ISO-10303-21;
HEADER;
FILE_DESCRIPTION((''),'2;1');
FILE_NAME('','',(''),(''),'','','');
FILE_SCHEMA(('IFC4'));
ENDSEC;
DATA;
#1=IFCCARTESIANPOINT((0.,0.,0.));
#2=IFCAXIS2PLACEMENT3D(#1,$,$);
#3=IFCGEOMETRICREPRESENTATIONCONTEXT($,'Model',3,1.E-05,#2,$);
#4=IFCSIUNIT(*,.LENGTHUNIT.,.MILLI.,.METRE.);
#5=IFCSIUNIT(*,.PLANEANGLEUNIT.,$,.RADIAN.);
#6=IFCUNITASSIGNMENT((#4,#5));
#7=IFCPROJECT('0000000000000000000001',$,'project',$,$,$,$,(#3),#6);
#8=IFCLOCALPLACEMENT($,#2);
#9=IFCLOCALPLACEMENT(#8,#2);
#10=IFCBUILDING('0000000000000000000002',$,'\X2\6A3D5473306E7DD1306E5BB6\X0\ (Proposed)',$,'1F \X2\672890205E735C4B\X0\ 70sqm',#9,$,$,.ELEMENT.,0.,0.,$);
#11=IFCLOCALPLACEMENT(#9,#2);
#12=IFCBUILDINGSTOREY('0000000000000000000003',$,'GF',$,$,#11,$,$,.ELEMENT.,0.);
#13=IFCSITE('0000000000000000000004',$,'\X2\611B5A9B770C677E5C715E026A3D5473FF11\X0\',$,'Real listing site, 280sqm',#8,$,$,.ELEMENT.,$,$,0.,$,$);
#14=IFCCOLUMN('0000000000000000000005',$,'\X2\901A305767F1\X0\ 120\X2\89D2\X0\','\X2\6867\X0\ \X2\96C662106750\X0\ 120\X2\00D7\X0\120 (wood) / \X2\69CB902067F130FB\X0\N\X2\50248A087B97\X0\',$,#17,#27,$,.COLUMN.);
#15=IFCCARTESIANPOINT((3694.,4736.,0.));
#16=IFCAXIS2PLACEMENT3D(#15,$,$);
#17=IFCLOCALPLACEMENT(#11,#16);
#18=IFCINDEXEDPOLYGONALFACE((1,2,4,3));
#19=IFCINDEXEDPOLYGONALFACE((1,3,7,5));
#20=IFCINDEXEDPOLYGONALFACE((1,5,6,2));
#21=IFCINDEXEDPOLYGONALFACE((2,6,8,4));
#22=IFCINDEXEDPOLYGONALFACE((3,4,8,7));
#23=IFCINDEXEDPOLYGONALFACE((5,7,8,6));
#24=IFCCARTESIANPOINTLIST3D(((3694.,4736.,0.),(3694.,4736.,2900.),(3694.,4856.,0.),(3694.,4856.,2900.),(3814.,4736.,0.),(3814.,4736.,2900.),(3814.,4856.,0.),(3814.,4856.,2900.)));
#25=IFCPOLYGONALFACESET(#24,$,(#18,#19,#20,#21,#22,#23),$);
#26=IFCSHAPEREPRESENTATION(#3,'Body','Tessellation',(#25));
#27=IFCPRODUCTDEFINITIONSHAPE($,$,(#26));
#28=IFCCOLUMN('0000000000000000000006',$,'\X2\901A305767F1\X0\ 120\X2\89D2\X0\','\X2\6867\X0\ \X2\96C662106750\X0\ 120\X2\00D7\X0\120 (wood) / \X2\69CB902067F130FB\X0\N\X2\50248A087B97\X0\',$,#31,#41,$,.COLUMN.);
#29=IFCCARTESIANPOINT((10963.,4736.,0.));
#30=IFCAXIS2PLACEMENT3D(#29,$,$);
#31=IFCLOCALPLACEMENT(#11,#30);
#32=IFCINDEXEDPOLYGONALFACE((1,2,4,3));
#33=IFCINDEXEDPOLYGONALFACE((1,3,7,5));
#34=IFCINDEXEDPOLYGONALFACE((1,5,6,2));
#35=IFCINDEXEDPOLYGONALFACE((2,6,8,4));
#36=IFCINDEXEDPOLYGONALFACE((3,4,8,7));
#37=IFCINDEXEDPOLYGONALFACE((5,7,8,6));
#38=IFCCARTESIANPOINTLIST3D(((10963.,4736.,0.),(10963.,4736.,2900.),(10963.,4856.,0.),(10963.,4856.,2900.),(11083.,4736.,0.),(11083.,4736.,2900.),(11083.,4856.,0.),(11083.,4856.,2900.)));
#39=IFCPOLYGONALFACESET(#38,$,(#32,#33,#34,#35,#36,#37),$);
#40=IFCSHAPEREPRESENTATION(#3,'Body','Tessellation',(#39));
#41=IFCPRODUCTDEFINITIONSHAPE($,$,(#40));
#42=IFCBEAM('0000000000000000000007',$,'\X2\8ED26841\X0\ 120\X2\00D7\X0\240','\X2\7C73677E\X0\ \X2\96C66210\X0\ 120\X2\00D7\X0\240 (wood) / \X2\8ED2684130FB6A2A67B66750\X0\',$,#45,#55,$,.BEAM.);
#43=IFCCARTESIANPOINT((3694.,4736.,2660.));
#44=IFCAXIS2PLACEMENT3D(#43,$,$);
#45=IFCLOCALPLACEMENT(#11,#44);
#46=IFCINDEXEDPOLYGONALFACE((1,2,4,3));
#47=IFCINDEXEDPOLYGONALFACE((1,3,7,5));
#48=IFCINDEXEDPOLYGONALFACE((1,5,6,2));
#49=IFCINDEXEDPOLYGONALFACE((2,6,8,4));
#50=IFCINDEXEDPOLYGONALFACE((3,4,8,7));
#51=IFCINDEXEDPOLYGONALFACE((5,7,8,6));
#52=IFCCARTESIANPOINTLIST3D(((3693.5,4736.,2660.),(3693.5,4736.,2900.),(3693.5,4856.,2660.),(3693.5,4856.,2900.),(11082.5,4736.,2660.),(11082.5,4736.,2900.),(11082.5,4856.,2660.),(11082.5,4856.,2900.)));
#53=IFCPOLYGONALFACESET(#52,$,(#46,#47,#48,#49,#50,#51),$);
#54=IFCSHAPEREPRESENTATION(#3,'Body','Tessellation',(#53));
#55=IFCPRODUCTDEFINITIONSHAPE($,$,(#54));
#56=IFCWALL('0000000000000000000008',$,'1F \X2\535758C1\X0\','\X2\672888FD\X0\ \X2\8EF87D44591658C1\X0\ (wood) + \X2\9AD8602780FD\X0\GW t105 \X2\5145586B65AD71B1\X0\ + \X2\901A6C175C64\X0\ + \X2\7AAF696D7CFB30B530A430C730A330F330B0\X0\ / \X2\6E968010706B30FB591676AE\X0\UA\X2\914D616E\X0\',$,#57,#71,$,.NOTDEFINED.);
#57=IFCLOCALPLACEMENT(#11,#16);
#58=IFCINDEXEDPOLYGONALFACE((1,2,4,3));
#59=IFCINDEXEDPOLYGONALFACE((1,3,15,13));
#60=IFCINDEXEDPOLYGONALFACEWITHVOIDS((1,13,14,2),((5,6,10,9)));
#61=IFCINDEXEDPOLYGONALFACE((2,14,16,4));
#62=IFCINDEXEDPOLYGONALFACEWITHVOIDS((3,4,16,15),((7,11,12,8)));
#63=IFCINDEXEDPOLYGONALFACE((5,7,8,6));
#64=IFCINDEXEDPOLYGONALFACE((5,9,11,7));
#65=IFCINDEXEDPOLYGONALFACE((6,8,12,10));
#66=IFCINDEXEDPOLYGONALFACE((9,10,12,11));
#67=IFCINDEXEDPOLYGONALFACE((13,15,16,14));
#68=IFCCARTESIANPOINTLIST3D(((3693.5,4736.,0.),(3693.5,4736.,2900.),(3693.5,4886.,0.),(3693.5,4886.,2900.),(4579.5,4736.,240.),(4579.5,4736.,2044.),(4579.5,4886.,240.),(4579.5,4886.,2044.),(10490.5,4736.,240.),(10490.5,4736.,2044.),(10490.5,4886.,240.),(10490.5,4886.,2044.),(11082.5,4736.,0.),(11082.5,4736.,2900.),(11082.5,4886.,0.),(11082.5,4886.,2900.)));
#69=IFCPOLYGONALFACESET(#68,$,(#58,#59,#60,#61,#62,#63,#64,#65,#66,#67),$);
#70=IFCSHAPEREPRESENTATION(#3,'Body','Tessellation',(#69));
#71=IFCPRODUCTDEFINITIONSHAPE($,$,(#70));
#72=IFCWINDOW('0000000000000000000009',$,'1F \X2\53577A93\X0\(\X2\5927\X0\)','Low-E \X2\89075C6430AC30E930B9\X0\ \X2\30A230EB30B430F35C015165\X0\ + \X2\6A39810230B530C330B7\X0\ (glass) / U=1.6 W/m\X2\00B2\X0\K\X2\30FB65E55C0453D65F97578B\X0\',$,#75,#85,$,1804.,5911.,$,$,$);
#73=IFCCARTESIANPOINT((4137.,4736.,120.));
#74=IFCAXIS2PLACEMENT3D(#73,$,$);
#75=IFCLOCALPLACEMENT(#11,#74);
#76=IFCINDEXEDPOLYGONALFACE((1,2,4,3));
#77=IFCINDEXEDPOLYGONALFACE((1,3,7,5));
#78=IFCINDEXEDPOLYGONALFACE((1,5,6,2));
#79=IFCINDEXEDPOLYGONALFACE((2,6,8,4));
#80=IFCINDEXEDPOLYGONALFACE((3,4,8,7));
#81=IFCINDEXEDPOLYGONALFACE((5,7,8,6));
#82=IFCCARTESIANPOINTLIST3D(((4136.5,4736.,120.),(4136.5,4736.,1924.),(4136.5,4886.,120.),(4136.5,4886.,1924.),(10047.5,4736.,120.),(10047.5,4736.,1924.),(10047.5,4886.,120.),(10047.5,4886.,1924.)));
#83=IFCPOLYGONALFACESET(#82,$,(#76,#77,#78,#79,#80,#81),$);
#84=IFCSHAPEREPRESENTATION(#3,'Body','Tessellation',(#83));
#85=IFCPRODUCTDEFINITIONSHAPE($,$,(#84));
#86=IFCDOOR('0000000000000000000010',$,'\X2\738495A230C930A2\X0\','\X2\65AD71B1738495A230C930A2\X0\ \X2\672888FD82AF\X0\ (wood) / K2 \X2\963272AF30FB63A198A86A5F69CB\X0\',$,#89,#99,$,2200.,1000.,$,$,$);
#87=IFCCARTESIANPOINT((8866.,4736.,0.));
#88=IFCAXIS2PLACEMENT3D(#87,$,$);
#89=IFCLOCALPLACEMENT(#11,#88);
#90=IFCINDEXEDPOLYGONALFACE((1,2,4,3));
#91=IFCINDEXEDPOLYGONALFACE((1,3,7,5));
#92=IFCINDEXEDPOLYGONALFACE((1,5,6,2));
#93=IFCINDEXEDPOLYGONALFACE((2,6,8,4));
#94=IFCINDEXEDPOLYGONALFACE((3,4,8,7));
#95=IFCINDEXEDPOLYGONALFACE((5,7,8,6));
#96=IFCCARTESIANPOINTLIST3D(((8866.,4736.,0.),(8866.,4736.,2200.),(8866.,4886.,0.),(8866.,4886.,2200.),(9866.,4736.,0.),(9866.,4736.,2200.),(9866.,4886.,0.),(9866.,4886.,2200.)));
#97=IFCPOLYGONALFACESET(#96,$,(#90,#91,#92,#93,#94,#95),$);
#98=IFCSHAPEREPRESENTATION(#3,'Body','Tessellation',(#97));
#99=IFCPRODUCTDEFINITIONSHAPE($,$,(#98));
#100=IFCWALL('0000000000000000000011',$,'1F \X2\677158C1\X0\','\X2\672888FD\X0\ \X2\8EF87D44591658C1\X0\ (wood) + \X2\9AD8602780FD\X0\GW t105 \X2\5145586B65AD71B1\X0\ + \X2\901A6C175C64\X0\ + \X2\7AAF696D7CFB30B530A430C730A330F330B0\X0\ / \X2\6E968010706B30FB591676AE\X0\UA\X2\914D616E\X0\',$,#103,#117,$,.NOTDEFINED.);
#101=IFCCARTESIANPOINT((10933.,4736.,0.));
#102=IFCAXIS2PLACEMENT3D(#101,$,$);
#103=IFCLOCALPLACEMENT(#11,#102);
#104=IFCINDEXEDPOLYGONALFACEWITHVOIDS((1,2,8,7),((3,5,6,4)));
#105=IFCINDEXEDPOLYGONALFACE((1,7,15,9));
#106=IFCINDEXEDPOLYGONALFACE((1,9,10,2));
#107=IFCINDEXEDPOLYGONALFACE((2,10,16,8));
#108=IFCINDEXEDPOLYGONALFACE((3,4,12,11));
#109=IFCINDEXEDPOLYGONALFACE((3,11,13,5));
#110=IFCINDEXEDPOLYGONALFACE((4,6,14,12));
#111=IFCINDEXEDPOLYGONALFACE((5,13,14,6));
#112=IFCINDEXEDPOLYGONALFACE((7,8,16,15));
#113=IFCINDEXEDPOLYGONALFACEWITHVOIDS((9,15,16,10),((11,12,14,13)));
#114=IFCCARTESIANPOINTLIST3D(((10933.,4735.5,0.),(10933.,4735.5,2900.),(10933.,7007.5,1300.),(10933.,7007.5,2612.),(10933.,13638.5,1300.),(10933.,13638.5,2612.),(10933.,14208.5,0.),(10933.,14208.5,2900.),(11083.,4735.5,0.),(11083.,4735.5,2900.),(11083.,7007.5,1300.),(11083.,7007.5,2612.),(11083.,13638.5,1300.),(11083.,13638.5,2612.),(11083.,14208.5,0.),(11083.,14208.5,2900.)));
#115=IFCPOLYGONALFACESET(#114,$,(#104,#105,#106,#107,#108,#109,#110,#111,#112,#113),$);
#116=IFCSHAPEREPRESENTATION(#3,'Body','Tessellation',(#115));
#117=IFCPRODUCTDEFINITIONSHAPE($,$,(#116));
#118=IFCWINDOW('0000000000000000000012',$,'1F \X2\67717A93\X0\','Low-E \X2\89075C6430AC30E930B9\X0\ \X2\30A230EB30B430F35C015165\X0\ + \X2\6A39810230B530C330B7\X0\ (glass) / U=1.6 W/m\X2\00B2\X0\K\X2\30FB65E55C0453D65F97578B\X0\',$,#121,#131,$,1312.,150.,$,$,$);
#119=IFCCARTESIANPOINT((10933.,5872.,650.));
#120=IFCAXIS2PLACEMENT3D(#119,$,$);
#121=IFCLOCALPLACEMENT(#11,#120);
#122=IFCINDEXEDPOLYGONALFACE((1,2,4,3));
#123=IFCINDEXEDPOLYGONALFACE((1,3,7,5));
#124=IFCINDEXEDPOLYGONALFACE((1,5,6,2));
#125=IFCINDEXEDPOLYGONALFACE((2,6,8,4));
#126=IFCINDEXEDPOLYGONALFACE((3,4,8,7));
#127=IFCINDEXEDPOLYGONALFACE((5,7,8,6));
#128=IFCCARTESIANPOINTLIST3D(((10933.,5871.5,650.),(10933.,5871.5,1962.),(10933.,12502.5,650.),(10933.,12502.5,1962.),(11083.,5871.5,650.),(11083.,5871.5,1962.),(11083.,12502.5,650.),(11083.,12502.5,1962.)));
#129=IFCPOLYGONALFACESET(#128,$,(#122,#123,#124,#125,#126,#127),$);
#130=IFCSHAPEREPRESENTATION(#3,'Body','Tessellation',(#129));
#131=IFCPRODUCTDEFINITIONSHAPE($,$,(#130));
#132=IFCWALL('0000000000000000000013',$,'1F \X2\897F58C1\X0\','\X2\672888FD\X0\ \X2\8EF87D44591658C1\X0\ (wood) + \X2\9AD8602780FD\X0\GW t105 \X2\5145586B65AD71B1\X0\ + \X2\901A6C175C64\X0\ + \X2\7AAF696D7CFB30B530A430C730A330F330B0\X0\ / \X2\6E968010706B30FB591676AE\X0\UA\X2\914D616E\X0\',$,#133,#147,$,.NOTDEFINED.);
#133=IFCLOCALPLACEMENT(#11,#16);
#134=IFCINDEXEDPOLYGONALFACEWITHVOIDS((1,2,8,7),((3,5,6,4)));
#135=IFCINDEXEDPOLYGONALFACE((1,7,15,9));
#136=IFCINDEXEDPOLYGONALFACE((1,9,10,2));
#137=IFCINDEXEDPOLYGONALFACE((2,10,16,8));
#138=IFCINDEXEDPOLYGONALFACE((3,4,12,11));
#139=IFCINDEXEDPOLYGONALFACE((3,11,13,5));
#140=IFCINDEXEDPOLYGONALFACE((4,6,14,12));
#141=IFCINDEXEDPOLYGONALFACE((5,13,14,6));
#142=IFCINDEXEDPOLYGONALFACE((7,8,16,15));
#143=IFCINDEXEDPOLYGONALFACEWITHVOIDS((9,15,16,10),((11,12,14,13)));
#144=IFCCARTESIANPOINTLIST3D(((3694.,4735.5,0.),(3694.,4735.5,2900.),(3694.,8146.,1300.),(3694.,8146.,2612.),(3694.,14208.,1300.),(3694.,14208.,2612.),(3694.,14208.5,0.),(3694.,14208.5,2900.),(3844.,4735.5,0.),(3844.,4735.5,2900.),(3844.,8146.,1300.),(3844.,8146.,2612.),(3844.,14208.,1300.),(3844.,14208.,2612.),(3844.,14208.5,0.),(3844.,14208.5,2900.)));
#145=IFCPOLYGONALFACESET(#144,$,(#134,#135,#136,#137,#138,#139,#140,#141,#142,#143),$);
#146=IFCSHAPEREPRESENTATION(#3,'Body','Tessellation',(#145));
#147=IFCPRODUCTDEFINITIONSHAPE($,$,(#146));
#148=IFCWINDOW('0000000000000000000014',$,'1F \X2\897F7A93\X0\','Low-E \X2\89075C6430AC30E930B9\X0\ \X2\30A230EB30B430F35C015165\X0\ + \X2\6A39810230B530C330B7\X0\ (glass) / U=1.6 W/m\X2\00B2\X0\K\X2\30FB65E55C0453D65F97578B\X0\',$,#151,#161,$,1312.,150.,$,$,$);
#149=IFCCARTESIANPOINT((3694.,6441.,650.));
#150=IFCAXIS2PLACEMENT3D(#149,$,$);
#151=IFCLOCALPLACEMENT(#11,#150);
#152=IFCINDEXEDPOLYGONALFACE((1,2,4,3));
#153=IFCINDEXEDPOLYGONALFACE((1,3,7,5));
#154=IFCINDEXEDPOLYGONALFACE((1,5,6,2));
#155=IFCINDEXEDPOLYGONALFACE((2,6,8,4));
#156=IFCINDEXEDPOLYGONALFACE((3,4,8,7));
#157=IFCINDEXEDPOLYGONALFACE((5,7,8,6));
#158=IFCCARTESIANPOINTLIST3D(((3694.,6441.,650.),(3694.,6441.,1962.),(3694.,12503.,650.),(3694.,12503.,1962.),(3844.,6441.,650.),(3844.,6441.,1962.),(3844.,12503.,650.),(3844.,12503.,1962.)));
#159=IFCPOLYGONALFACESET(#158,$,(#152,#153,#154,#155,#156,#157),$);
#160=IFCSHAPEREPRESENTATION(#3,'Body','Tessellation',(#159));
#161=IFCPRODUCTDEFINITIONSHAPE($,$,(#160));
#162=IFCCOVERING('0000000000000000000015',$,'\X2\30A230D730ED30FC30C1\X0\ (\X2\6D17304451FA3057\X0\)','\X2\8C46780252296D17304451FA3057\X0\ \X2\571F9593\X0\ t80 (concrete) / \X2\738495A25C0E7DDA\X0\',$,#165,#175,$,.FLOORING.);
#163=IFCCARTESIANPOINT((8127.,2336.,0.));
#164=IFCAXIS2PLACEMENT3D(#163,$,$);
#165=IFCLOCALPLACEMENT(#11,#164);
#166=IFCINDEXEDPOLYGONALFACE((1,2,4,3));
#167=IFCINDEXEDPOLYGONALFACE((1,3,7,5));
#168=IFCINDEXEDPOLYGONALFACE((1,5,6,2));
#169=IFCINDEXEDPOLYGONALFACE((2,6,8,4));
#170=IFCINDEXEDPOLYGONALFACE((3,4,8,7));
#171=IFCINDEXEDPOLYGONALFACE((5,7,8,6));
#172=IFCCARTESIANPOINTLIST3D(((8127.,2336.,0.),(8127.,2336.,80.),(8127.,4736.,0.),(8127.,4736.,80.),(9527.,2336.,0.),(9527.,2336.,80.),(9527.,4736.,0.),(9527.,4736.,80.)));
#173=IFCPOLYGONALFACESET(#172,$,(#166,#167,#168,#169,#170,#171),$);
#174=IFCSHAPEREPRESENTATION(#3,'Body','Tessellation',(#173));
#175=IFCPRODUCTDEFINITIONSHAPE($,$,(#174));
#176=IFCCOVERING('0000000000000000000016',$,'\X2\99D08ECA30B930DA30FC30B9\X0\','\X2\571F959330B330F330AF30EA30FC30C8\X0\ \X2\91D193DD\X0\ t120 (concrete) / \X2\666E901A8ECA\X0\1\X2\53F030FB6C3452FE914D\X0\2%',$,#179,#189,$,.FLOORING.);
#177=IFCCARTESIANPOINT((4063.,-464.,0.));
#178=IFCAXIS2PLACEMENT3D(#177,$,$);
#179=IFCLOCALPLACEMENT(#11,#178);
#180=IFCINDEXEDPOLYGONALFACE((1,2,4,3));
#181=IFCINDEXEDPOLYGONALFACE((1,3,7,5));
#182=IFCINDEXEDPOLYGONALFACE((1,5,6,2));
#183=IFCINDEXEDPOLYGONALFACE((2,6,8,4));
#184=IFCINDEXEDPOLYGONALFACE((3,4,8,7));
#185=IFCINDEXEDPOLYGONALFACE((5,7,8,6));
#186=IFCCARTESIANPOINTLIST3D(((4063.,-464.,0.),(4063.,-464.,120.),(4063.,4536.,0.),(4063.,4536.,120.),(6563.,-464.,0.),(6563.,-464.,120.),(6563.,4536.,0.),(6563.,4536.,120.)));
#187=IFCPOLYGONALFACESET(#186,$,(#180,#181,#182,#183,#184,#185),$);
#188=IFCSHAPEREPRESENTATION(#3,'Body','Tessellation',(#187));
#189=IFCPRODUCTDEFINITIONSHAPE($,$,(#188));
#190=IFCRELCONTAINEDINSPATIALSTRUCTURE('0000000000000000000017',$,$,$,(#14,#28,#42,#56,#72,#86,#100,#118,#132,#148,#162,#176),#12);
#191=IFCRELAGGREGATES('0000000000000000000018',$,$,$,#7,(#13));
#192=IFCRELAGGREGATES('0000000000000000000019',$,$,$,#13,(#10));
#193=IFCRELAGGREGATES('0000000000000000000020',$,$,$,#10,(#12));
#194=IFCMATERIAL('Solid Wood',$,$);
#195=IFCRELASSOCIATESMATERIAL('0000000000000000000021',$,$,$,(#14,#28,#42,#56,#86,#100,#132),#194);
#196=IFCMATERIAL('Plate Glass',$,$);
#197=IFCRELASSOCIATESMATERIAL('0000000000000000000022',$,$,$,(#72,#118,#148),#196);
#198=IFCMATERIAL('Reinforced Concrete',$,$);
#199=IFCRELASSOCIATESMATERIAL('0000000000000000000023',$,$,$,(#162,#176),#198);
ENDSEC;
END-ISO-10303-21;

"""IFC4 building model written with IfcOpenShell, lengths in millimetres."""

from ifc_helpers import new_model, si_unit, frame, frame_2d, origin, place, context, project, spatial, rectangle, extrude, material, element, fill, save


model = new_model("IFC4")

# Units and contexts
model_context = context("Model", 3, precision=1e-05, world=origin())
ifc_project = project(units=[si_unit("LENGTHUNIT", "METRE", prefix="MILLI"), si_unit("PLANEANGLEUNIT", "RADIAN")], contexts=[model_context])

# Site, building, storey
site_placement = place(None, origin())
site = spatial("IfcSite", under=ifc_project, at=site_placement, Name="愛媛県松山市樽味１", ObjectType="Real listing site, 280sqm", CompositionType="ELEMENT", RefElevation=0.0)
building_placement = place(site_placement, origin())
building = spatial("IfcBuilding", under=site, at=building_placement, Name="樽味の緑の家 (Proposed)", ObjectType="1F 木造平屋 70sqm", CompositionType="ELEMENT", ElevationOfRefHeight=0.0, ElevationOfTerrain=0.0)
storey_placement = place(building_placement, origin())
storey = spatial("IfcBuildingStorey", under=building, at=storey_placement, Name="GF", CompositionType="ELEMENT", Elevation=0.0)

# Columns
ifc_material_1 = material(Name="Solid Wood")
column_1_placement = place(storey_placement, frame((3694.0, 4736.0, 0.0)))
element("IfcColumn", 1, at=column_1_placement, inside=storey, material=ifc_material_1, Name="通し柱 120角", Description="桧 集成材 120×120 (wood) / 構造柱・N値計算", PredefinedType="COLUMN", context=model_context, shape_type="SweptSolid", body=[
    extrude(rectangle(XDim=120.0, YDim=120.0, at=frame_2d((60.0, 60.0))), frame((3694.0, 4736.0, 0.0)), (0.0, 0.0, 1.0), 2900.0),
])
column_2_placement = place(storey_placement, frame((10963.0, 4736.0, 0.0)))
element("IfcColumn", 2, at=column_2_placement, inside=storey, material=ifc_material_1, Name="通し柱 120角", Description="桧 集成材 120×120 (wood) / 構造柱・N値計算", PredefinedType="COLUMN", context=model_context, shape_type="SweptSolid", body=[
    extrude(rectangle(XDim=120.0, YDim=120.0, at=frame_2d((60.0, 60.0))), frame((10963.0, 4736.0, 0.0)), (0.0, 0.0, 1.0), 2900.0),
])

# Beam
beam_1_placement = place(storey_placement, frame((3694.0, 4736.0, 2660.0)))
element("IfcBeam", 3, at=beam_1_placement, inside=storey, material=ifc_material_1, Name="軒桁 120×240", Description="米松 集成 120×240 (wood) / 軒桁・横架材", PredefinedType="BEAM", context=model_context, shape_type="SweptSolid", body=[
    extrude(rectangle(XDim=7389.0, YDim=120.0, at=frame_2d((3694.0, 60.0))), frame((3694.0, 4736.0, 2660.0)), (0.0, 0.0, 1.0), 240.0),
])

# Shared definitions
ifc_material_2 = material(Name="Reinforced Concrete")

# Wall, openings, window, door
wall_1_placement = place(storey_placement, frame((3694.0, 4736.0, 0.0)))
wall_1 = element("IfcWall", 4, at=wall_1_placement, inside=storey, material=ifc_material_1, Name="1F 南壁", Description="木製 軸組外壁 (wood) + 高性能GW t105 充填断熱 + 通気層 + 窯業系サイディング / 準耐火・外皮UA配慮", PredefinedType="NOTDEFINED", context=model_context, shape_type="SweptSolid", body=[
    extrude(rectangle(XDim=7389.0, YDim=150.0, at=frame_2d((3694.0, 75.0))), frame((3694.0, 4736.0, 0.0)), (0.0, 0.0, 1.0), 2900.0),
])
opening_1_placement = place(storey_placement, frame((4137.0, 4736.0, 120.0)))
opening_1 = element("IfcOpeningElement", 5, at=opening_1_placement, cuts=wall_1, PredefinedType="NOTDEFINED", context=model_context, shape_type="SweptSolid", body=[
    extrude(rectangle(XDim=5911.0, YDim=150.0, at=frame_2d((2955.0, 75.0))), frame((4137.0, 4736.0, 120.0)), (0.0, 0.0, 1.0), 1804.0),
])
opening_2_placement = place(storey_placement, frame((8866.0, 4736.0, 0.0)))
opening_2 = element("IfcOpeningElement", 6, at=opening_2_placement, cuts=wall_1, PredefinedType="NOTDEFINED", context=model_context, shape_type="SweptSolid", body=[
    extrude(rectangle(XDim=1000.0, YDim=150.0, at=frame_2d((500.0, 75.0))), frame((8866.0, 4736.0, 0.0)), (0.0, 0.0, 1.0), 2200.0),
])
ifc_material_3 = material(Name="Plate Glass")
window_1_placement = place(storey_placement, frame((4137.0, 4736.0, 120.0)))
window_1 = element("IfcWindow", 7, at=window_1_placement, inside=storey, material=ifc_material_3, Name="1F 南窓(大)", Description="Low-E 複層ガラス アルゴン封入 + 樹脂サッシ (glass) / U=1.6 W/m²K・日射取得型", OverallHeight=1804.0, OverallWidth=5911.0, context=model_context, shape_type="SweptSolid", body=[
    extrude(rectangle(XDim=5911.0, YDim=150.0, at=frame_2d((2955.0, 75.0))), frame((4137.0, 4736.0, 120.0)), (0.0, 0.0, 1.0), 1804.0),
])
fill(opening_1, window_1)
door_placement = place(storey_placement, frame((8866.0, 4736.0, 0.0)))
door = element("IfcDoor", 8, at=door_placement, inside=storey, material=ifc_material_1, Name="玄関ドア", Description="断熱玄関ドア 木製芯 (wood) / K2 防犯・採風機構", OverallHeight=2200.0, OverallWidth=1000.0, context=model_context, shape_type="SweptSolid", body=[
    extrude(rectangle(XDim=1000.0, YDim=150.0, at=frame_2d((500.0, 75.0))), frame((8866.0, 4736.0, 0.0)), (0.0, 0.0, 1.0), 2200.0),
])
fill(opening_2, door)

# Walls, openings, windows
wall_2_placement = place(storey_placement, frame((10933.0, 4736.0, 0.0)))
wall_2 = element("IfcWall", 9, at=wall_2_placement, inside=storey, material=ifc_material_1, Name="1F 東壁", Description="木製 軸組外壁 (wood) + 高性能GW t105 充填断熱 + 通気層 + 窯業系サイディング / 準耐火・外皮UA配慮", PredefinedType="NOTDEFINED", context=model_context, shape_type="SweptSolid", body=[
    extrude(rectangle(XDim=150.0, YDim=9473.0, at=frame_2d((75.0, 4736.0))), frame((10933.0, 4736.0, 0.0)), (0.0, 0.0, 1.0), 2900.0),
])
opening_3_placement = place(storey_placement, frame((10933.0, 5872.0, 650.0)))
opening_3 = element("IfcOpeningElement", 10, at=opening_3_placement, cuts=wall_2, PredefinedType="NOTDEFINED", context=model_context, shape_type="SweptSolid", body=[
    extrude(rectangle(XDim=150.0, YDim=6631.0, at=frame_2d((75.0, 3315.0))), frame((10933.0, 5872.0, 650.0)), (0.0, 0.0, 1.0), 1312.0),
])
window_2_placement = place(storey_placement, frame((10933.0, 5872.0, 650.0)))
window_2 = element("IfcWindow", 11, at=window_2_placement, inside=storey, material=ifc_material_3, Name="1F 東窓", Description="Low-E 複層ガラス アルゴン封入 + 樹脂サッシ (glass) / U=1.6 W/m²K・日射取得型", OverallHeight=1312.0, OverallWidth=150.0, context=model_context, shape_type="SweptSolid", body=[
    extrude(rectangle(XDim=150.0, YDim=6631.0, at=frame_2d((75.0, 3315.0))), frame((10933.0, 5872.0, 650.0)), (0.0, 0.0, 1.0), 1312.0),
])
fill(opening_3, window_2)
wall_3_placement = place(storey_placement, frame((3694.0, 4736.0, 0.0)))
wall_3 = element("IfcWall", 12, at=wall_3_placement, inside=storey, material=ifc_material_1, Name="1F 西壁", Description="木製 軸組外壁 (wood) + 高性能GW t105 充填断熱 + 通気層 + 窯業系サイディング / 準耐火・外皮UA配慮", PredefinedType="NOTDEFINED", context=model_context, shape_type="SweptSolid", body=[
    extrude(rectangle(XDim=150.0, YDim=9473.0, at=frame_2d((75.0, 4736.0))), frame((3694.0, 4736.0, 0.0)), (0.0, 0.0, 1.0), 2900.0),
])
opening_4_placement = place(storey_placement, frame((3694.0, 6441.0, 650.0)))
opening_4 = element("IfcOpeningElement", 13, at=opening_4_placement, cuts=wall_3, PredefinedType="NOTDEFINED", context=model_context, shape_type="SweptSolid", body=[
    extrude(rectangle(XDim=150.0, YDim=6062.0, at=frame_2d((75.0, 3031.0))), frame((3694.0, 6441.0, 650.0)), (0.0, 0.0, 1.0), 1312.0),
])
window_3_placement = place(storey_placement, frame((3694.0, 6441.0, 650.0)))
window_3 = element("IfcWindow", 14, at=window_3_placement, inside=storey, material=ifc_material_3, Name="1F 西窓", Description="Low-E 複層ガラス アルゴン封入 + 樹脂サッシ (glass) / U=1.6 W/m²K・日射取得型", OverallHeight=1312.0, OverallWidth=150.0, context=model_context, shape_type="SweptSolid", body=[
    extrude(rectangle(XDim=150.0, YDim=6062.0, at=frame_2d((75.0, 3031.0))), frame((3694.0, 6441.0, 650.0)), (0.0, 0.0, 1.0), 1312.0),
])
fill(opening_4, window_3)

# Coverings
covering_1_placement = place(storey_placement, frame((8127.0, 2336.0, 0.0)))
element("IfcCovering", 15, at=covering_1_placement, inside=storey, material=ifc_material_2, Name="アプローチ (洗い出し)", Description="豆砂利洗い出し 土間 t80 (concrete) / 玄関導線", PredefinedType="FLOORING", context=model_context, shape_type="SweptSolid", body=[
    extrude(rectangle(XDim=1400.0, YDim=2400.0, at=frame_2d((700.0, 1200.0))), frame((8127.0, 2336.0, 0.0)), (0.0, 0.0, 1.0), 80.0),
])
covering_2_placement = place(storey_placement, frame((4063.0, -464.0, 0.0)))
element("IfcCovering", 16, at=covering_2_placement, inside=storey, material=ifc_material_2, Name="駐車スペース", Description="土間コンクリート 金鏝 t120 (concrete) / 普通車1台・水勾配2%", PredefinedType="FLOORING", context=model_context, shape_type="SweptSolid", body=[
    extrude(rectangle(XDim=2500.0, YDim=5000.0, at=frame_2d((1250.0, 2500.0))), frame((4063.0, -464.0, 0.0)), (0.0, 0.0, 1.0), 120.0),
])

save(model, "model.ifc")
